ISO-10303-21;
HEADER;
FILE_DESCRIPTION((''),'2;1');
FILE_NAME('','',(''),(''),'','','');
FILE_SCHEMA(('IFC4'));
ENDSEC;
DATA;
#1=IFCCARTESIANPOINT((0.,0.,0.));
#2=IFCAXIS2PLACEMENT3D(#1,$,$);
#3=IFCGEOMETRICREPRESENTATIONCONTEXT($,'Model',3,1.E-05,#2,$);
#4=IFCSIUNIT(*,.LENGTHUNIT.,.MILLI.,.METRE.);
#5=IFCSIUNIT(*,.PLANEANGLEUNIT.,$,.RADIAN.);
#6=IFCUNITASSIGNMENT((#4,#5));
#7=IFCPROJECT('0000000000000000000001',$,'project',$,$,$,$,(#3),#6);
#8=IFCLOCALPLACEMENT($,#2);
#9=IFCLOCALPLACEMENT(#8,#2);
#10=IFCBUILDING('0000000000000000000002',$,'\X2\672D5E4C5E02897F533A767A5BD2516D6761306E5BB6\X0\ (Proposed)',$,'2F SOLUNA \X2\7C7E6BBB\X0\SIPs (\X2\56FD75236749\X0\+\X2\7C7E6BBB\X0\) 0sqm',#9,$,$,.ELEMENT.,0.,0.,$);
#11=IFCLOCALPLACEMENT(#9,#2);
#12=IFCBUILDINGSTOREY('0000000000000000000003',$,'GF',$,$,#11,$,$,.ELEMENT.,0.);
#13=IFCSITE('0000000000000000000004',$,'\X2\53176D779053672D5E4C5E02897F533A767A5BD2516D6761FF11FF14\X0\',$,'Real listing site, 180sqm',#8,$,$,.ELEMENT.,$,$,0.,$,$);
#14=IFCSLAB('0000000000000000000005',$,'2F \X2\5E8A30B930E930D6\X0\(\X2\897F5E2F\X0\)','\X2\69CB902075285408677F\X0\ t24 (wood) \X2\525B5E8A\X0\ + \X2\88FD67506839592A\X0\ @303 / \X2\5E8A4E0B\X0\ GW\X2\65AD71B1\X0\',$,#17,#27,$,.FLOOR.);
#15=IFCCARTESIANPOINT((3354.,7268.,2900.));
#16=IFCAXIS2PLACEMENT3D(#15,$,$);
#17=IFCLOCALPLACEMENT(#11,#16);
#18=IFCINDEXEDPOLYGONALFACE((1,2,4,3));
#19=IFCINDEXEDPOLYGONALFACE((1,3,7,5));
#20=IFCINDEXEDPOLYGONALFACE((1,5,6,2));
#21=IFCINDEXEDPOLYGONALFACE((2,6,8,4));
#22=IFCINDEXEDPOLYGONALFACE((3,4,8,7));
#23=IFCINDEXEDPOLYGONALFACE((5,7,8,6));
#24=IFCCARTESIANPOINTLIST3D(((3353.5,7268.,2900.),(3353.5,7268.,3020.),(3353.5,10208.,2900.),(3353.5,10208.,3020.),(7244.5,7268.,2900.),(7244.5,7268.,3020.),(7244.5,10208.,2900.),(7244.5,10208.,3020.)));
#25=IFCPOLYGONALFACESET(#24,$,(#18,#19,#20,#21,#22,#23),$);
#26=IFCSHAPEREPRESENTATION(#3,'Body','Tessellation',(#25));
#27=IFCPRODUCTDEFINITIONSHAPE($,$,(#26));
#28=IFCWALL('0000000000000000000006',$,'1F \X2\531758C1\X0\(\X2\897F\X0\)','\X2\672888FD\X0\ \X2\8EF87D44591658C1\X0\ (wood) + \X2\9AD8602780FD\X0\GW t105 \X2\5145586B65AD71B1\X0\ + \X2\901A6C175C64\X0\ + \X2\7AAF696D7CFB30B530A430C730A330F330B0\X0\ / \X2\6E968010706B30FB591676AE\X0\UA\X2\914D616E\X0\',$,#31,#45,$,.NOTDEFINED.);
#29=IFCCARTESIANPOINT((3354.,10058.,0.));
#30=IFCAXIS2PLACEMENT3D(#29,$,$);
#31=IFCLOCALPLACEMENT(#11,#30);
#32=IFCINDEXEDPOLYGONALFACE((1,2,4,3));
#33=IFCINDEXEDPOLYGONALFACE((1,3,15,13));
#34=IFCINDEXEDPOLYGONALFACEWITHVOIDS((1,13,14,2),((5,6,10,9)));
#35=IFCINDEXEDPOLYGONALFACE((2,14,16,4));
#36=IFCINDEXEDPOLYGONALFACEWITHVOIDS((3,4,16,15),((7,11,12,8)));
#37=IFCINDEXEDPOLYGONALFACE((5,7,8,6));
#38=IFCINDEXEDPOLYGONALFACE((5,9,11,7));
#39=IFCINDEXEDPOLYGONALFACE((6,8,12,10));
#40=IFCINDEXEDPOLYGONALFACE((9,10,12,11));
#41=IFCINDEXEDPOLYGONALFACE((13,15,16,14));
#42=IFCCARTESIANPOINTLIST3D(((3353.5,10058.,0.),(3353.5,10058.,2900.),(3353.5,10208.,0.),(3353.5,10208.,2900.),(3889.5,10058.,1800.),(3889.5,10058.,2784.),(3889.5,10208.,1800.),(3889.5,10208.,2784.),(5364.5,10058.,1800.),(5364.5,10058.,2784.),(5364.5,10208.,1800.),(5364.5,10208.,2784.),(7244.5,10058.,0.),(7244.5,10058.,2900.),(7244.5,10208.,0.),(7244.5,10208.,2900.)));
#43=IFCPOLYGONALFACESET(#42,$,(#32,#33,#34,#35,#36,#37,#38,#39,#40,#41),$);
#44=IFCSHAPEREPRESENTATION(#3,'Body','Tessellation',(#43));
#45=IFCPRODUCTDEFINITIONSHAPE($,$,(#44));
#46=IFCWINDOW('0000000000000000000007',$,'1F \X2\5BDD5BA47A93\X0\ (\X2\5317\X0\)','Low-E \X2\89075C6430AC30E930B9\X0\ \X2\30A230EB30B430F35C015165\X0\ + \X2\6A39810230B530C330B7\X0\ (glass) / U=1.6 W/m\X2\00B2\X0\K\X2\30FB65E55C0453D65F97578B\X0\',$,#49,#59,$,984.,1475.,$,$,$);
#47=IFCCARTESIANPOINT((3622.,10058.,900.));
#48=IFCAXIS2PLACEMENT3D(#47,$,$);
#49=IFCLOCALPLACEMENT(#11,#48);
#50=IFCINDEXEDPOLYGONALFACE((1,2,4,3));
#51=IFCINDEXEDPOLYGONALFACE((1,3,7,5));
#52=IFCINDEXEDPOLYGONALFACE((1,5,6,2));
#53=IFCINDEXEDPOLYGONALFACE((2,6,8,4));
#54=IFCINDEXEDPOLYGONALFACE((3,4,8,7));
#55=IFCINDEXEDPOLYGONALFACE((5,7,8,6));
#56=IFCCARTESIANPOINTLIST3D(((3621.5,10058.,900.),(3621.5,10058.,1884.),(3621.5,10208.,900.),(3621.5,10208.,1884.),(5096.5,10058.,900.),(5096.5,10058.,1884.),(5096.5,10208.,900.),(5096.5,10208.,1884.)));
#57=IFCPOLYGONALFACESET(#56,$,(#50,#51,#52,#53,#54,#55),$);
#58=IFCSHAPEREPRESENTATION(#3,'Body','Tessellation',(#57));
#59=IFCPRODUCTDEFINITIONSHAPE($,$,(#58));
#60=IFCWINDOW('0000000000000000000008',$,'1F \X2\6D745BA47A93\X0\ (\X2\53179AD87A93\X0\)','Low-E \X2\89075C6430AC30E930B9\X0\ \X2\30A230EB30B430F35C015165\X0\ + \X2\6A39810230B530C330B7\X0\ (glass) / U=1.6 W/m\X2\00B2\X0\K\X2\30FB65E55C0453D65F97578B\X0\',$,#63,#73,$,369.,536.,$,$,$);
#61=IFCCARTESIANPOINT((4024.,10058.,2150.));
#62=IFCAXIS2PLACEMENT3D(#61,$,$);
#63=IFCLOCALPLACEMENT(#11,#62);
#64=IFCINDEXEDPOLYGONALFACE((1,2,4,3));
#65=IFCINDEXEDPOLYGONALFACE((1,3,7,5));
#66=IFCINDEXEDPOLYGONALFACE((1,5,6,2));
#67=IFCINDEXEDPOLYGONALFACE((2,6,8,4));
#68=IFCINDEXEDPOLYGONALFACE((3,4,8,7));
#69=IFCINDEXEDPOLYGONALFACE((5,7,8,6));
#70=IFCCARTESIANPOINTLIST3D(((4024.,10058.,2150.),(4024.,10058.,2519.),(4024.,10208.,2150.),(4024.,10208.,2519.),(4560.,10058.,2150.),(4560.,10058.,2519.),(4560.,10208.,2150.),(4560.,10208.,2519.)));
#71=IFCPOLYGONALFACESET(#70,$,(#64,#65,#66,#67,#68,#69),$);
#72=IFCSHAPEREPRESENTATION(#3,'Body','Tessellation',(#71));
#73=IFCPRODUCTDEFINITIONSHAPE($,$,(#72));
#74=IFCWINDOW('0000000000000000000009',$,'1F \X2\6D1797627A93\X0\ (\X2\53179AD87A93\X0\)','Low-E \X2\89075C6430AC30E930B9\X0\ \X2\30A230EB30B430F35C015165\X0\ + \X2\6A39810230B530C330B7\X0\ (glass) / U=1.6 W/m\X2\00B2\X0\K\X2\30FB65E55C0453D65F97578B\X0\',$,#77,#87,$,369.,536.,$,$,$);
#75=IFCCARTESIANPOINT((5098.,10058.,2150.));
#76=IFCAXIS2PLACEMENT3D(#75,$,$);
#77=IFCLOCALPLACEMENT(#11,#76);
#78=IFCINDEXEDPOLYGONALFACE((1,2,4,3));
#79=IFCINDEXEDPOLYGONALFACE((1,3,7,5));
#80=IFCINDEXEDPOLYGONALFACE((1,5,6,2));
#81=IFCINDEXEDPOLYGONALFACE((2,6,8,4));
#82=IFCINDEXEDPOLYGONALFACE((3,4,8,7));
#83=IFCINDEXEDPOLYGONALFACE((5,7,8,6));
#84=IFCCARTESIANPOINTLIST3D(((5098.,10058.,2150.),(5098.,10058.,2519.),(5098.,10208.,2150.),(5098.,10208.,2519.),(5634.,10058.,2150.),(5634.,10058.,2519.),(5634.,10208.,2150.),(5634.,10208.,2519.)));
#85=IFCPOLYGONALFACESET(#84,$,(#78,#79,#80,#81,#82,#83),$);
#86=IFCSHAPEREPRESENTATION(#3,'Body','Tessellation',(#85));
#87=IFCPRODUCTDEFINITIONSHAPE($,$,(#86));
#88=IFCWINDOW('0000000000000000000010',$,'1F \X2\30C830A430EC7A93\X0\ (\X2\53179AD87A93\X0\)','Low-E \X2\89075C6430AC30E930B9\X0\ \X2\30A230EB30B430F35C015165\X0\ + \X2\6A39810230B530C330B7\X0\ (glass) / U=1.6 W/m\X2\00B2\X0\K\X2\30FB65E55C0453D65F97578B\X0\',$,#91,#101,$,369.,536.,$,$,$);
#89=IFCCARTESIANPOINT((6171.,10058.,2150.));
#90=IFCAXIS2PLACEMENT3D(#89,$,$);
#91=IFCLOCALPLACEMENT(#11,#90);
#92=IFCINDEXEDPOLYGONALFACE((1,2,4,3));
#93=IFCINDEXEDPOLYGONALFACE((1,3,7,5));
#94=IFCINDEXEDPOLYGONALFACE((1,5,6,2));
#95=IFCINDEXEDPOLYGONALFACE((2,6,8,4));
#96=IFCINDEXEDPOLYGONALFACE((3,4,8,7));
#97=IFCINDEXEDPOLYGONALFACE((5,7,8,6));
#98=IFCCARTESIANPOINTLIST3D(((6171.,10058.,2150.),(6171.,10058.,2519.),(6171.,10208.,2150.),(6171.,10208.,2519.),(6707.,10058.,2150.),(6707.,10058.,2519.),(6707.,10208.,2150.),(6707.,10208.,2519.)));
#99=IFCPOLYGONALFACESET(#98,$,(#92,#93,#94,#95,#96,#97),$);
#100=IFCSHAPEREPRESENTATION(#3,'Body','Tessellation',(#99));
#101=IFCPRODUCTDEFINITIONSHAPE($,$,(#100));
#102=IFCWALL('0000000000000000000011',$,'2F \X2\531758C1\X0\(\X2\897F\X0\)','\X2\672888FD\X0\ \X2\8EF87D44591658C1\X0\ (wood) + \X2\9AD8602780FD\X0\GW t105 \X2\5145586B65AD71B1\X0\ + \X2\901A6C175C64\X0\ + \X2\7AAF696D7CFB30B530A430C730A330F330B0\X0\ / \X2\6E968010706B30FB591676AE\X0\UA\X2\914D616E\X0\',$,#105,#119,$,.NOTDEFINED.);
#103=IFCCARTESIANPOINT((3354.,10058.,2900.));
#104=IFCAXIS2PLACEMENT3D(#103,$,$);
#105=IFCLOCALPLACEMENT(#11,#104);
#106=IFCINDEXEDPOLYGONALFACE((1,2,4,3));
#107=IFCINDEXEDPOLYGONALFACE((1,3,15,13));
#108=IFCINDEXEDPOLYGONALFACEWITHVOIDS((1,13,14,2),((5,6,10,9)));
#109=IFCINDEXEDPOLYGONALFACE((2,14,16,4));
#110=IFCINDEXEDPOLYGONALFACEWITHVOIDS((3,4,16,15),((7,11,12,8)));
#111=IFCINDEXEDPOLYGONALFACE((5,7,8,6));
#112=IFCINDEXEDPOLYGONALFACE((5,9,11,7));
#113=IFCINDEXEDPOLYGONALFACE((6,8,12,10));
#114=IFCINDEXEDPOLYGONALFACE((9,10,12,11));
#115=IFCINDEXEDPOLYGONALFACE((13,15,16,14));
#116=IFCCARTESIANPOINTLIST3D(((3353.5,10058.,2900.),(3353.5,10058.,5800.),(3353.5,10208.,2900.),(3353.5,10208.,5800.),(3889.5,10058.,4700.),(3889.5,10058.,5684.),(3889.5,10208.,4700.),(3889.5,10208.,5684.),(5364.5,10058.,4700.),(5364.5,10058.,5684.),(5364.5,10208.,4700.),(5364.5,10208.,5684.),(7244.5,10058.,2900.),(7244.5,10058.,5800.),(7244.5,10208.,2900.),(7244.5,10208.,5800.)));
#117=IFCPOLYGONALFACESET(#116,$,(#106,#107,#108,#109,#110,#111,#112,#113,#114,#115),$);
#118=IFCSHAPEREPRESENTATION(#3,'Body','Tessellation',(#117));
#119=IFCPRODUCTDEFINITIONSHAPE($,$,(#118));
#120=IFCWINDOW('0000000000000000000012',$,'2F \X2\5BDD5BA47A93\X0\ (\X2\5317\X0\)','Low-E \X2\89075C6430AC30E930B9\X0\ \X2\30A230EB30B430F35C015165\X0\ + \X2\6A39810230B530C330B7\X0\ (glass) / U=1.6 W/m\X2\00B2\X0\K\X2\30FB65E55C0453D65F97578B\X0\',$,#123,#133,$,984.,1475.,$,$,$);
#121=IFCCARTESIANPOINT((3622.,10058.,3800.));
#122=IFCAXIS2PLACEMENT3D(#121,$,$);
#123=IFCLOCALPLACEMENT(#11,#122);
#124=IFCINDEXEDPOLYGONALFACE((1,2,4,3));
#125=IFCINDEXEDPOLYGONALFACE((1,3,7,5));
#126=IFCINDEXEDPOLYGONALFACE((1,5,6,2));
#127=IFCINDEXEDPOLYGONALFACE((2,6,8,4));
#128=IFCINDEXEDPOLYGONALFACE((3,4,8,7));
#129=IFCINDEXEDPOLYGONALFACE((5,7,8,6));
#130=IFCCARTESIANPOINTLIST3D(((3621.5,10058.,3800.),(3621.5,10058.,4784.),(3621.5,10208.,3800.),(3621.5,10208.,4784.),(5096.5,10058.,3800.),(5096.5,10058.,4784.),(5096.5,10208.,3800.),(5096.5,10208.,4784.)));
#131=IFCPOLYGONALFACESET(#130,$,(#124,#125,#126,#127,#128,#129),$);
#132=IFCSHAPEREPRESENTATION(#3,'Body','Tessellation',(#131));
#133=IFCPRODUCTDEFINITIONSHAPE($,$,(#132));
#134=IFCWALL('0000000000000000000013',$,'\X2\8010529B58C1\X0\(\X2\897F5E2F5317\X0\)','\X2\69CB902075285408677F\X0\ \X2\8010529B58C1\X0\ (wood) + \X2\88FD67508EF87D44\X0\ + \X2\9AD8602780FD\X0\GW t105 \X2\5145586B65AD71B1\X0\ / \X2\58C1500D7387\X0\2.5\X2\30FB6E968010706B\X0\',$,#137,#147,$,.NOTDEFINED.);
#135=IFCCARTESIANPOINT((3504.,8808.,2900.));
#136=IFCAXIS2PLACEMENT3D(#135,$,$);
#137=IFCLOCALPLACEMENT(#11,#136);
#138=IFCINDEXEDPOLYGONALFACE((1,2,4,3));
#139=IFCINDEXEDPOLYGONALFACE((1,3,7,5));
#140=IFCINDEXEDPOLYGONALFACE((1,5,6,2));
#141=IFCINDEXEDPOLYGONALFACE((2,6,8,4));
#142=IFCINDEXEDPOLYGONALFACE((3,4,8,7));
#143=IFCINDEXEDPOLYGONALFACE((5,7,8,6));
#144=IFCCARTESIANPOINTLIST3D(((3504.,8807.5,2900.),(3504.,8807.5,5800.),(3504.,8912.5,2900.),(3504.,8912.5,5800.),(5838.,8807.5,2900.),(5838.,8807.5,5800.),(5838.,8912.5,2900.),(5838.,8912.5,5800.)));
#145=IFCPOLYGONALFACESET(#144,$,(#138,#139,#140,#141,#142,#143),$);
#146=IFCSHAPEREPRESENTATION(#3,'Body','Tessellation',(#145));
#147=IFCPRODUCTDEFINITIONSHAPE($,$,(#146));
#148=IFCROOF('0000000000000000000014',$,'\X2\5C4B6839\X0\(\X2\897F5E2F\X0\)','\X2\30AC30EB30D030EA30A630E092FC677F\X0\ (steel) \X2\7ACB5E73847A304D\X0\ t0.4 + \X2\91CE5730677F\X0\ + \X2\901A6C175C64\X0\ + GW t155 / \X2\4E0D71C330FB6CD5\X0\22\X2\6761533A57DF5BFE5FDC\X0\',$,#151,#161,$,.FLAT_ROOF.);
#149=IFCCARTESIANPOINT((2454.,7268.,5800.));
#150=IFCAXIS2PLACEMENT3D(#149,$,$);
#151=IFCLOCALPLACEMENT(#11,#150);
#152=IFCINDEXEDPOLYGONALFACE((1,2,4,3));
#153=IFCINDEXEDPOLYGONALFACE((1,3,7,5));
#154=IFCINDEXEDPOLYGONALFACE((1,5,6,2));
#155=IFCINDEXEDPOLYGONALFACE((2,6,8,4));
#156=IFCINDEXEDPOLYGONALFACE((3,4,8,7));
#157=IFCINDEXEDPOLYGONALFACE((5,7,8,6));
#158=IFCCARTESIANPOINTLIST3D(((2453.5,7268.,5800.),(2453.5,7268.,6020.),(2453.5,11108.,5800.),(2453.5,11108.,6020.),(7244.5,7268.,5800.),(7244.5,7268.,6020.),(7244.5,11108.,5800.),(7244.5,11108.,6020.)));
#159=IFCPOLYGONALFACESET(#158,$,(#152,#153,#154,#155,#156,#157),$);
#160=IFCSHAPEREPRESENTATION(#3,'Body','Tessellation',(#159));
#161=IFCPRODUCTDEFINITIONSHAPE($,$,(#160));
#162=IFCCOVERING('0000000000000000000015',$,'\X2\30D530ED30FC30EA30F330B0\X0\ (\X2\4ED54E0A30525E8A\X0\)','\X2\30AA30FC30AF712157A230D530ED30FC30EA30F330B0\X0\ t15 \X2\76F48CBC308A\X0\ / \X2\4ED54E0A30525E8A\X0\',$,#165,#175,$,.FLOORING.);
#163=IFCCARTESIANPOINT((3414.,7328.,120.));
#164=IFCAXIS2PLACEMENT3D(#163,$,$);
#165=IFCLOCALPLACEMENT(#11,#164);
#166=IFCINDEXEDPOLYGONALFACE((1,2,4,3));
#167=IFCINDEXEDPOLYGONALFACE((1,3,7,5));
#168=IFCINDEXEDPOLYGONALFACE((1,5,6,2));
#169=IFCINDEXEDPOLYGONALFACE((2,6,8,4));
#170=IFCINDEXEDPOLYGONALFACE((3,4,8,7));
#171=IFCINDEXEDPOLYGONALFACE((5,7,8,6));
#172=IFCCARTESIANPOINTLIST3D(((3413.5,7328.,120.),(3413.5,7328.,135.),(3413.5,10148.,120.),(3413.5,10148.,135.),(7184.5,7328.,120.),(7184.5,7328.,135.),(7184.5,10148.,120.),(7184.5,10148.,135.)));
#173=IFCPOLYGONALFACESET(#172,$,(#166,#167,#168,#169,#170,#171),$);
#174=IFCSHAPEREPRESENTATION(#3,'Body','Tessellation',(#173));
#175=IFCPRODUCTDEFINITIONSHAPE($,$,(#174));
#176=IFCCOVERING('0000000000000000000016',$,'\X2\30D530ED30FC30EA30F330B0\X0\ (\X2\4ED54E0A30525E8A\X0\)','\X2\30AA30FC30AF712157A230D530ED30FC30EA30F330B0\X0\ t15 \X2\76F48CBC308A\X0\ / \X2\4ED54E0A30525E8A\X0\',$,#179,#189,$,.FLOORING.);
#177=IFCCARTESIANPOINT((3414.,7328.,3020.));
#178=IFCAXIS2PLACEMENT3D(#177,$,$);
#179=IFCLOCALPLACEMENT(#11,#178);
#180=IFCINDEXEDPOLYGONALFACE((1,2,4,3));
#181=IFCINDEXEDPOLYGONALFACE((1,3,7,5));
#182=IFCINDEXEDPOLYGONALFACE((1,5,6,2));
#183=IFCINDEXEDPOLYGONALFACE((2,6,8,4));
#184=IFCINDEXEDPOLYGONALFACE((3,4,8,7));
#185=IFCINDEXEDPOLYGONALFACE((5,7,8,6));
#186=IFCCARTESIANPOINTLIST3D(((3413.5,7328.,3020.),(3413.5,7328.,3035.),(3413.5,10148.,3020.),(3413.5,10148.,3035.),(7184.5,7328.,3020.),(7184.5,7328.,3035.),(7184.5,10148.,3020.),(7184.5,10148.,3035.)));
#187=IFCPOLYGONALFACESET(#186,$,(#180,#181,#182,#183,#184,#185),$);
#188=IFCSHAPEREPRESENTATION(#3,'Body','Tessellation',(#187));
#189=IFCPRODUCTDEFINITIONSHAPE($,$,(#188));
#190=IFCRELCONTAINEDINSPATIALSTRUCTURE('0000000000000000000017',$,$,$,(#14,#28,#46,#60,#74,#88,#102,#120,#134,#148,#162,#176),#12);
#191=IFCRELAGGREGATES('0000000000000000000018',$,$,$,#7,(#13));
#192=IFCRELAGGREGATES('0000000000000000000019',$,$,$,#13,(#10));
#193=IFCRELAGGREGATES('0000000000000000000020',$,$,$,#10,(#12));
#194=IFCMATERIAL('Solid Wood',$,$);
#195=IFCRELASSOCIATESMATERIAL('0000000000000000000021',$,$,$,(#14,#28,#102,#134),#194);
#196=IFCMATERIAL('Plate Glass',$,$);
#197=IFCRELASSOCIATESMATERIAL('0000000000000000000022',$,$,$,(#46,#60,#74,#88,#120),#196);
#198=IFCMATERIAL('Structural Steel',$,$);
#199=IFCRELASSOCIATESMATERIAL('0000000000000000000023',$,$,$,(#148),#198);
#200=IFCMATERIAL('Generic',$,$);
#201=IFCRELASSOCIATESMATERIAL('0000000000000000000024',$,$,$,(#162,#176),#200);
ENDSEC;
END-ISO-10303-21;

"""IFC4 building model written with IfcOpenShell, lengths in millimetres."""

from ifc_helpers import new_model, si_unit, frame, frame_2d, origin, place, context, project, spatial, rectangle, extrude, material, element, fill, save


model = new_model("IFC4")

# Units and contexts
model_context = context("Model", 3, precision=1e-05, world=origin())
ifc_project = project(units=[si_unit("LENGTHUNIT", "METRE", prefix="MILLI"), si_unit("PLANEANGLEUNIT", "RADIAN")], contexts=[model_context])

# Site, building, storey
site_placement = place(None, origin())
site = spatial("IfcSite", under=ifc_project, at=site_placement, Name="北海道札幌市西区発寒六条１４", ObjectType="Real listing site, 180sqm", CompositionType="ELEMENT", RefElevation=0.0)
building_placement = place(site_placement, origin())
building = spatial("IfcBuilding", under=site, at=building_placement, Name="札幌市西区発寒六条の家 (Proposed)", ObjectType="2F SOLUNA 籾殻SIPs (国産杉+籾殻) 0sqm", CompositionType="ELEMENT", ElevationOfRefHeight=0.0, ElevationOfTerrain=0.0)
storey_placement = place(building_placement, origin())
storey = spatial("IfcBuildingStorey", under=building, at=storey_placement, Name="GF", CompositionType="ELEMENT", Elevation=0.0)

# Slab
ifc_material_1 = material(Name="Solid Wood")
slab_1_placement = place(storey_placement, frame((3354.0, 7268.0, 2900.0)))
element("IfcSlab", 1, at=slab_1_placement, inside=storey, material=ifc_material_1, Name="2F 床スラブ(西帯)", Description="構造用合板 t24 (wood) 剛床 + 製材根太 @303 / 床下 GW断熱", PredefinedType="FLOOR", context=model_context, shape_type="SweptSolid", body=[
    extrude(rectangle(XDim=3891.0, YDim=2940.0, at=frame_2d((1945.0, 1470.0))), frame((3354.0, 7268.0, 2900.0)), (0.0, 0.0, 1.0), 120.0),
])

# Wall, openings, windows
wall_1_placement = place(storey_placement, frame((3354.0, 10058.0, 0.0)))
wall_1 = element("IfcWall", 2, at=wall_1_placement, inside=storey, material=ifc_material_1, Name="1F 北壁(西)", Description="木製 軸組外壁 (wood) + 高性能GW t105 充填断熱 + 通気層 + 窯業系サイディング / 準耐火・外皮UA配慮", PredefinedType="NOTDEFINED", context=model_context, shape_type="SweptSolid", body=[
    extrude(rectangle(XDim=3891.0, YDim=150.0, at=frame_2d((1945.0, 75.0))), frame((3354.0, 10058.0, 0.0)), (0.0, 0.0, 1.0), 2900.0),
])
opening_1_placement = place(storey_placement, frame((3622.0, 10058.0, 900.0)))
opening_1 = element("IfcOpeningElement", 3, at=opening_1_placement, cuts=wall_1, PredefinedType="NOTDEFINED", context=model_context, shape_type="SweptSolid", body=[
    extrude(rectangle(XDim=1475.0, YDim=150.0, at=frame_2d((737.0, 75.0))), frame((3622.0, 10058.0, 900.0)), (0.0, 0.0, 1.0), 984.0),
])
opening_2_placement = place(storey_placement, frame((4024.0, 10058.0, 2150.0)))
opening_2 = element("IfcOpeningElement", 4, at=opening_2_placement, cuts=wall_1, PredefinedType="NOTDEFINED", context=model_context, shape_type="SweptSolid", body=[
    extrude(rectangle(XDim=536.0, YDim=150.0, at=frame_2d((268.0, 75.0))), frame((4024.0, 10058.0, 2150.0)), (0.0, 0.0, 1.0), 369.0),
])
opening_3_placement = place(storey_placement, frame((5098.0, 10058.0, 2150.0)))
opening_3 = element("IfcOpeningElement", 5, at=opening_3_placement, cuts=wall_1, PredefinedType="NOTDEFINED", context=model_context, shape_type="SweptSolid", body=[
    extrude(rectangle(XDim=536.0, YDim=150.0, at=frame_2d((268.0, 75.0))), frame((5098.0, 10058.0, 2150.0)), (0.0, 0.0, 1.0), 369.0),
])
opening_4_placement = place(storey_placement, frame((6171.0, 10058.0, 2150.0)))
opening_4 = element("IfcOpeningElement", 6, at=opening_4_placement, cuts=wall_1, PredefinedType="NOTDEFINED", context=model_context, shape_type="SweptSolid", body=[
    extrude(rectangle(XDim=536.0, YDim=150.0, at=frame_2d((268.0, 75.0))), frame((6171.0, 10058.0, 2150.0)), (0.0, 0.0, 1.0), 369.0),
])
ifc_material_2 = material(Name="Plate Glass")
window_1_placement = place(storey_placement, frame((3622.0, 10058.0, 900.0)))
window_1 = element("IfcWindow", 7, at=window_1_placement, inside=storey, material=ifc_material_2, Name="1F 寝室窓 (北)", Description="Low-E 複層ガラス アルゴン封入 + 樹脂サッシ (glass) / U=1.6 W/m²K・日射取得型", OverallHeight=984.0, OverallWidth=1475.0, context=model_context, shape_type="SweptSolid", body=[
    extrude(rectangle(XDim=1475.0, YDim=150.0, at=frame_2d((737.0, 75.0))), frame((3622.0, 10058.0, 900.0)), (0.0, 0.0, 1.0), 984.0),
])
fill(opening_1, window_1)
window_2_placement = place(storey_placement, frame((4024.0, 10058.0, 2150.0)))
window_2 = element("IfcWindow", 8, at=window_2_placement, inside=storey, material=ifc_material_2, Name="1F 浴室窓 (北高窓)", Description="Low-E 複層ガラス アルゴン封入 + 樹脂サッシ (glass) / U=1.6 W/m²K・日射取得型", OverallHeight=369.0, OverallWidth=536.0, context=model_context, shape_type="SweptSolid", body=[
    extrude(rectangle(XDim=536.0, YDim=150.0, at=frame_2d((268.0, 75.0))), frame((4024.0, 10058.0, 2150.0)), (0.0, 0.0, 1.0), 369.0),
])
fill(opening_2, window_2)
window_3_placement = place(storey_placement, frame((5098.0, 10058.0, 2150.0)))
window_3 = element("IfcWindow", 9, at=window_3_placement, inside=storey, material=ifc_material_2, Name="1F 洗面窓 (北高窓)", Description="Low-E 複層ガラス アルゴン封入 + 樹脂サッシ (glass) / U=1.6 W/m²K・日射取得型", OverallHeight=369.0, OverallWidth=536.0, context=model_context, shape_type="SweptSolid", body=[
    extrude(rectangle(XDim=536.0, YDim=150.0, at=frame_2d((268.0, 75.0))), frame((5098.0, 10058.0, 2150.0)), (0.0, 0.0, 1.0), 369.0),
])
fill(opening_3, window_3)
window_4_placement = place(storey_placement, frame((6171.0, 10058.0, 2150.0)))
window_4 = element("IfcWindow", 10, at=window_4_placement, inside=storey, material=ifc_material_2, Name="1F トイレ窓 (北高窓)", Description="Low-E 複層ガラス アルゴン封入 + 樹脂サッシ (glass) / U=1.6 W/m²K・日射取得型", OverallHeight=369.0, OverallWidth=536.0, context=model_context, shape_type="SweptSolid", body=[
    extrude(rectangle(XDim=536.0, YDim=150.0, at=frame_2d((268.0, 75.0))), frame((6171.0, 10058.0, 2150.0)), (0.0, 0.0, 1.0), 369.0),
])
fill(opening_4, window_4)

# Wall, opening, window
wall_2_placement = place(storey_placement, frame((3354.0, 10058.0, 2900.0)))
wall_2 = element("IfcWall", 11, at=wall_2_placement, inside=storey, material=ifc_material_1, Name="2F 北壁(西)", Description="木製 軸組外壁 (wood) + 高性能GW t105 充填断熱 + 通気層 + 窯業系サイディング / 準耐火・外皮UA配慮", PredefinedType="NOTDEFINED", context=model_context, shape_type="SweptSolid", body=[
    extrude(rectangle(XDim=3891.0, YDim=150.0, at=frame_2d((1945.0, 75.0))), frame((3354.0, 10058.0, 2900.0)), (0.0, 0.0, 1.0), 2900.0),
])
opening_5_placement = place(storey_placement, frame((3622.0, 10058.0, 3800.0)))
opening_5 = element("IfcOpeningElement", 12, at=opening_5_placement, cuts=wall_2, PredefinedType="NOTDEFINED", context=model_context, shape_type="SweptSolid", body=[
    extrude(rectangle(XDim=1475.0, YDim=150.0, at=frame_2d((737.0, 75.0))), frame((3622.0, 10058.0, 3800.0)), (0.0, 0.0, 1.0), 984.0),
])
window_5_placement = place(storey_placement, frame((3622.0, 10058.0, 3800.0)))
window_5 = element("IfcWindow", 13, at=window_5_placement, inside=storey, material=ifc_material_2, Name="2F 寝室窓 (北)", Description="Low-E 複層ガラス アルゴン封入 + 樹脂サッシ (glass) / U=1.6 W/m²K・日射取得型", OverallHeight=984.0, OverallWidth=1475.0, context=model_context, shape_type="SweptSolid", body=[
    extrude(rectangle(XDim=1475.0, YDim=150.0, at=frame_2d((737.0, 75.0))), frame((3622.0, 10058.0, 3800.0)), (0.0, 0.0, 1.0), 984.0),
])
fill(opening_5, window_5)

# Wall
wall_3_placement = place(storey_placement, frame((3504.0, 8808.0, 2900.0)))
element("IfcWall", 14, at=wall_3_placement, inside=storey, material=ifc_material_1, Name="耐力壁(西帯北)", Description="構造用合板 耐力壁 (wood) + 製材軸組 + 高性能GW t105 充填断熱 / 壁倍率2.5・準耐火", PredefinedType="NOTDEFINED", context=model_context, shape_type="SweptSolid", body=[
    extrude(rectangle(XDim=2334.0, YDim=105.0, at=frame_2d((1167.0, 52.0))), frame((3504.0, 8808.0, 2900.0)), (0.0, 0.0, 1.0), 2900.0),
])

# Roof
ifc_material_3 = material(Name="Structural Steel")
for number, where, name in (
    (15, (2454.0, 7268.0, 5800.0), "屋根(西帯)"),
):
    element("IfcRoof", number, at=place(storey_placement, frame(where)), inside=storey, material=ifc_material_3, Name=name, Description="ガルバリウム鋼板 (steel) 立平葺き t0.4 + 野地板 + 通気層 + GW t155 / 不燃・法22条区域対応", PredefinedType="FLAT_ROOF", context=model_context, shape_type="SweptSolid", body=[
        extrude(rectangle(XDim=4791.0, YDim=3840.0, at=frame_2d((2395.0, 1920.0))), frame((2454.0, 7268.0, 5800.0)), (0.0, 0.0, 1.0), 220.0),
    ])

# Coverings
ifc_material_4 = material(Name="Generic")
covering_1_placement = place(storey_placement, frame((3414.0, 7328.0, 120.0)))
element("IfcCovering", 16, at=covering_1_placement, inside=storey, material=ifc_material_4, Name="フローリング (仕上げ床)", Description="オーク無垢フローリング t15 直貼り / 仕上げ床", PredefinedType="FLOORING", context=model_context, shape_type="SweptSolid", body=[
    extrude(rectangle(XDim=3771.0, YDim=2820.0, at=frame_2d((1885.0, 1410.0))), frame((3414.0, 7328.0, 120.0)), (0.0, 0.0, 1.0), 15.0),
])
covering_2_placement = place(storey_placement, frame((3414.0, 7328.0, 3020.0)))
element("IfcCovering", 17, at=covering_2_placement, inside=storey, material=ifc_material_4, Name="フローリング (仕上げ床)", Description="オーク無垢フローリング t15 直貼り / 仕上げ床", PredefinedType="FLOORING", context=model_context, shape_type="SweptSolid", body=[
    extrude(rectangle(XDim=3771.0, YDim=2820.0, at=frame_2d((1885.0, 1410.0))), frame((3414.0, 7328.0, 3020.0)), (0.0, 0.0, 1.0), 15.0),
])

save(model, "model.ifc")
